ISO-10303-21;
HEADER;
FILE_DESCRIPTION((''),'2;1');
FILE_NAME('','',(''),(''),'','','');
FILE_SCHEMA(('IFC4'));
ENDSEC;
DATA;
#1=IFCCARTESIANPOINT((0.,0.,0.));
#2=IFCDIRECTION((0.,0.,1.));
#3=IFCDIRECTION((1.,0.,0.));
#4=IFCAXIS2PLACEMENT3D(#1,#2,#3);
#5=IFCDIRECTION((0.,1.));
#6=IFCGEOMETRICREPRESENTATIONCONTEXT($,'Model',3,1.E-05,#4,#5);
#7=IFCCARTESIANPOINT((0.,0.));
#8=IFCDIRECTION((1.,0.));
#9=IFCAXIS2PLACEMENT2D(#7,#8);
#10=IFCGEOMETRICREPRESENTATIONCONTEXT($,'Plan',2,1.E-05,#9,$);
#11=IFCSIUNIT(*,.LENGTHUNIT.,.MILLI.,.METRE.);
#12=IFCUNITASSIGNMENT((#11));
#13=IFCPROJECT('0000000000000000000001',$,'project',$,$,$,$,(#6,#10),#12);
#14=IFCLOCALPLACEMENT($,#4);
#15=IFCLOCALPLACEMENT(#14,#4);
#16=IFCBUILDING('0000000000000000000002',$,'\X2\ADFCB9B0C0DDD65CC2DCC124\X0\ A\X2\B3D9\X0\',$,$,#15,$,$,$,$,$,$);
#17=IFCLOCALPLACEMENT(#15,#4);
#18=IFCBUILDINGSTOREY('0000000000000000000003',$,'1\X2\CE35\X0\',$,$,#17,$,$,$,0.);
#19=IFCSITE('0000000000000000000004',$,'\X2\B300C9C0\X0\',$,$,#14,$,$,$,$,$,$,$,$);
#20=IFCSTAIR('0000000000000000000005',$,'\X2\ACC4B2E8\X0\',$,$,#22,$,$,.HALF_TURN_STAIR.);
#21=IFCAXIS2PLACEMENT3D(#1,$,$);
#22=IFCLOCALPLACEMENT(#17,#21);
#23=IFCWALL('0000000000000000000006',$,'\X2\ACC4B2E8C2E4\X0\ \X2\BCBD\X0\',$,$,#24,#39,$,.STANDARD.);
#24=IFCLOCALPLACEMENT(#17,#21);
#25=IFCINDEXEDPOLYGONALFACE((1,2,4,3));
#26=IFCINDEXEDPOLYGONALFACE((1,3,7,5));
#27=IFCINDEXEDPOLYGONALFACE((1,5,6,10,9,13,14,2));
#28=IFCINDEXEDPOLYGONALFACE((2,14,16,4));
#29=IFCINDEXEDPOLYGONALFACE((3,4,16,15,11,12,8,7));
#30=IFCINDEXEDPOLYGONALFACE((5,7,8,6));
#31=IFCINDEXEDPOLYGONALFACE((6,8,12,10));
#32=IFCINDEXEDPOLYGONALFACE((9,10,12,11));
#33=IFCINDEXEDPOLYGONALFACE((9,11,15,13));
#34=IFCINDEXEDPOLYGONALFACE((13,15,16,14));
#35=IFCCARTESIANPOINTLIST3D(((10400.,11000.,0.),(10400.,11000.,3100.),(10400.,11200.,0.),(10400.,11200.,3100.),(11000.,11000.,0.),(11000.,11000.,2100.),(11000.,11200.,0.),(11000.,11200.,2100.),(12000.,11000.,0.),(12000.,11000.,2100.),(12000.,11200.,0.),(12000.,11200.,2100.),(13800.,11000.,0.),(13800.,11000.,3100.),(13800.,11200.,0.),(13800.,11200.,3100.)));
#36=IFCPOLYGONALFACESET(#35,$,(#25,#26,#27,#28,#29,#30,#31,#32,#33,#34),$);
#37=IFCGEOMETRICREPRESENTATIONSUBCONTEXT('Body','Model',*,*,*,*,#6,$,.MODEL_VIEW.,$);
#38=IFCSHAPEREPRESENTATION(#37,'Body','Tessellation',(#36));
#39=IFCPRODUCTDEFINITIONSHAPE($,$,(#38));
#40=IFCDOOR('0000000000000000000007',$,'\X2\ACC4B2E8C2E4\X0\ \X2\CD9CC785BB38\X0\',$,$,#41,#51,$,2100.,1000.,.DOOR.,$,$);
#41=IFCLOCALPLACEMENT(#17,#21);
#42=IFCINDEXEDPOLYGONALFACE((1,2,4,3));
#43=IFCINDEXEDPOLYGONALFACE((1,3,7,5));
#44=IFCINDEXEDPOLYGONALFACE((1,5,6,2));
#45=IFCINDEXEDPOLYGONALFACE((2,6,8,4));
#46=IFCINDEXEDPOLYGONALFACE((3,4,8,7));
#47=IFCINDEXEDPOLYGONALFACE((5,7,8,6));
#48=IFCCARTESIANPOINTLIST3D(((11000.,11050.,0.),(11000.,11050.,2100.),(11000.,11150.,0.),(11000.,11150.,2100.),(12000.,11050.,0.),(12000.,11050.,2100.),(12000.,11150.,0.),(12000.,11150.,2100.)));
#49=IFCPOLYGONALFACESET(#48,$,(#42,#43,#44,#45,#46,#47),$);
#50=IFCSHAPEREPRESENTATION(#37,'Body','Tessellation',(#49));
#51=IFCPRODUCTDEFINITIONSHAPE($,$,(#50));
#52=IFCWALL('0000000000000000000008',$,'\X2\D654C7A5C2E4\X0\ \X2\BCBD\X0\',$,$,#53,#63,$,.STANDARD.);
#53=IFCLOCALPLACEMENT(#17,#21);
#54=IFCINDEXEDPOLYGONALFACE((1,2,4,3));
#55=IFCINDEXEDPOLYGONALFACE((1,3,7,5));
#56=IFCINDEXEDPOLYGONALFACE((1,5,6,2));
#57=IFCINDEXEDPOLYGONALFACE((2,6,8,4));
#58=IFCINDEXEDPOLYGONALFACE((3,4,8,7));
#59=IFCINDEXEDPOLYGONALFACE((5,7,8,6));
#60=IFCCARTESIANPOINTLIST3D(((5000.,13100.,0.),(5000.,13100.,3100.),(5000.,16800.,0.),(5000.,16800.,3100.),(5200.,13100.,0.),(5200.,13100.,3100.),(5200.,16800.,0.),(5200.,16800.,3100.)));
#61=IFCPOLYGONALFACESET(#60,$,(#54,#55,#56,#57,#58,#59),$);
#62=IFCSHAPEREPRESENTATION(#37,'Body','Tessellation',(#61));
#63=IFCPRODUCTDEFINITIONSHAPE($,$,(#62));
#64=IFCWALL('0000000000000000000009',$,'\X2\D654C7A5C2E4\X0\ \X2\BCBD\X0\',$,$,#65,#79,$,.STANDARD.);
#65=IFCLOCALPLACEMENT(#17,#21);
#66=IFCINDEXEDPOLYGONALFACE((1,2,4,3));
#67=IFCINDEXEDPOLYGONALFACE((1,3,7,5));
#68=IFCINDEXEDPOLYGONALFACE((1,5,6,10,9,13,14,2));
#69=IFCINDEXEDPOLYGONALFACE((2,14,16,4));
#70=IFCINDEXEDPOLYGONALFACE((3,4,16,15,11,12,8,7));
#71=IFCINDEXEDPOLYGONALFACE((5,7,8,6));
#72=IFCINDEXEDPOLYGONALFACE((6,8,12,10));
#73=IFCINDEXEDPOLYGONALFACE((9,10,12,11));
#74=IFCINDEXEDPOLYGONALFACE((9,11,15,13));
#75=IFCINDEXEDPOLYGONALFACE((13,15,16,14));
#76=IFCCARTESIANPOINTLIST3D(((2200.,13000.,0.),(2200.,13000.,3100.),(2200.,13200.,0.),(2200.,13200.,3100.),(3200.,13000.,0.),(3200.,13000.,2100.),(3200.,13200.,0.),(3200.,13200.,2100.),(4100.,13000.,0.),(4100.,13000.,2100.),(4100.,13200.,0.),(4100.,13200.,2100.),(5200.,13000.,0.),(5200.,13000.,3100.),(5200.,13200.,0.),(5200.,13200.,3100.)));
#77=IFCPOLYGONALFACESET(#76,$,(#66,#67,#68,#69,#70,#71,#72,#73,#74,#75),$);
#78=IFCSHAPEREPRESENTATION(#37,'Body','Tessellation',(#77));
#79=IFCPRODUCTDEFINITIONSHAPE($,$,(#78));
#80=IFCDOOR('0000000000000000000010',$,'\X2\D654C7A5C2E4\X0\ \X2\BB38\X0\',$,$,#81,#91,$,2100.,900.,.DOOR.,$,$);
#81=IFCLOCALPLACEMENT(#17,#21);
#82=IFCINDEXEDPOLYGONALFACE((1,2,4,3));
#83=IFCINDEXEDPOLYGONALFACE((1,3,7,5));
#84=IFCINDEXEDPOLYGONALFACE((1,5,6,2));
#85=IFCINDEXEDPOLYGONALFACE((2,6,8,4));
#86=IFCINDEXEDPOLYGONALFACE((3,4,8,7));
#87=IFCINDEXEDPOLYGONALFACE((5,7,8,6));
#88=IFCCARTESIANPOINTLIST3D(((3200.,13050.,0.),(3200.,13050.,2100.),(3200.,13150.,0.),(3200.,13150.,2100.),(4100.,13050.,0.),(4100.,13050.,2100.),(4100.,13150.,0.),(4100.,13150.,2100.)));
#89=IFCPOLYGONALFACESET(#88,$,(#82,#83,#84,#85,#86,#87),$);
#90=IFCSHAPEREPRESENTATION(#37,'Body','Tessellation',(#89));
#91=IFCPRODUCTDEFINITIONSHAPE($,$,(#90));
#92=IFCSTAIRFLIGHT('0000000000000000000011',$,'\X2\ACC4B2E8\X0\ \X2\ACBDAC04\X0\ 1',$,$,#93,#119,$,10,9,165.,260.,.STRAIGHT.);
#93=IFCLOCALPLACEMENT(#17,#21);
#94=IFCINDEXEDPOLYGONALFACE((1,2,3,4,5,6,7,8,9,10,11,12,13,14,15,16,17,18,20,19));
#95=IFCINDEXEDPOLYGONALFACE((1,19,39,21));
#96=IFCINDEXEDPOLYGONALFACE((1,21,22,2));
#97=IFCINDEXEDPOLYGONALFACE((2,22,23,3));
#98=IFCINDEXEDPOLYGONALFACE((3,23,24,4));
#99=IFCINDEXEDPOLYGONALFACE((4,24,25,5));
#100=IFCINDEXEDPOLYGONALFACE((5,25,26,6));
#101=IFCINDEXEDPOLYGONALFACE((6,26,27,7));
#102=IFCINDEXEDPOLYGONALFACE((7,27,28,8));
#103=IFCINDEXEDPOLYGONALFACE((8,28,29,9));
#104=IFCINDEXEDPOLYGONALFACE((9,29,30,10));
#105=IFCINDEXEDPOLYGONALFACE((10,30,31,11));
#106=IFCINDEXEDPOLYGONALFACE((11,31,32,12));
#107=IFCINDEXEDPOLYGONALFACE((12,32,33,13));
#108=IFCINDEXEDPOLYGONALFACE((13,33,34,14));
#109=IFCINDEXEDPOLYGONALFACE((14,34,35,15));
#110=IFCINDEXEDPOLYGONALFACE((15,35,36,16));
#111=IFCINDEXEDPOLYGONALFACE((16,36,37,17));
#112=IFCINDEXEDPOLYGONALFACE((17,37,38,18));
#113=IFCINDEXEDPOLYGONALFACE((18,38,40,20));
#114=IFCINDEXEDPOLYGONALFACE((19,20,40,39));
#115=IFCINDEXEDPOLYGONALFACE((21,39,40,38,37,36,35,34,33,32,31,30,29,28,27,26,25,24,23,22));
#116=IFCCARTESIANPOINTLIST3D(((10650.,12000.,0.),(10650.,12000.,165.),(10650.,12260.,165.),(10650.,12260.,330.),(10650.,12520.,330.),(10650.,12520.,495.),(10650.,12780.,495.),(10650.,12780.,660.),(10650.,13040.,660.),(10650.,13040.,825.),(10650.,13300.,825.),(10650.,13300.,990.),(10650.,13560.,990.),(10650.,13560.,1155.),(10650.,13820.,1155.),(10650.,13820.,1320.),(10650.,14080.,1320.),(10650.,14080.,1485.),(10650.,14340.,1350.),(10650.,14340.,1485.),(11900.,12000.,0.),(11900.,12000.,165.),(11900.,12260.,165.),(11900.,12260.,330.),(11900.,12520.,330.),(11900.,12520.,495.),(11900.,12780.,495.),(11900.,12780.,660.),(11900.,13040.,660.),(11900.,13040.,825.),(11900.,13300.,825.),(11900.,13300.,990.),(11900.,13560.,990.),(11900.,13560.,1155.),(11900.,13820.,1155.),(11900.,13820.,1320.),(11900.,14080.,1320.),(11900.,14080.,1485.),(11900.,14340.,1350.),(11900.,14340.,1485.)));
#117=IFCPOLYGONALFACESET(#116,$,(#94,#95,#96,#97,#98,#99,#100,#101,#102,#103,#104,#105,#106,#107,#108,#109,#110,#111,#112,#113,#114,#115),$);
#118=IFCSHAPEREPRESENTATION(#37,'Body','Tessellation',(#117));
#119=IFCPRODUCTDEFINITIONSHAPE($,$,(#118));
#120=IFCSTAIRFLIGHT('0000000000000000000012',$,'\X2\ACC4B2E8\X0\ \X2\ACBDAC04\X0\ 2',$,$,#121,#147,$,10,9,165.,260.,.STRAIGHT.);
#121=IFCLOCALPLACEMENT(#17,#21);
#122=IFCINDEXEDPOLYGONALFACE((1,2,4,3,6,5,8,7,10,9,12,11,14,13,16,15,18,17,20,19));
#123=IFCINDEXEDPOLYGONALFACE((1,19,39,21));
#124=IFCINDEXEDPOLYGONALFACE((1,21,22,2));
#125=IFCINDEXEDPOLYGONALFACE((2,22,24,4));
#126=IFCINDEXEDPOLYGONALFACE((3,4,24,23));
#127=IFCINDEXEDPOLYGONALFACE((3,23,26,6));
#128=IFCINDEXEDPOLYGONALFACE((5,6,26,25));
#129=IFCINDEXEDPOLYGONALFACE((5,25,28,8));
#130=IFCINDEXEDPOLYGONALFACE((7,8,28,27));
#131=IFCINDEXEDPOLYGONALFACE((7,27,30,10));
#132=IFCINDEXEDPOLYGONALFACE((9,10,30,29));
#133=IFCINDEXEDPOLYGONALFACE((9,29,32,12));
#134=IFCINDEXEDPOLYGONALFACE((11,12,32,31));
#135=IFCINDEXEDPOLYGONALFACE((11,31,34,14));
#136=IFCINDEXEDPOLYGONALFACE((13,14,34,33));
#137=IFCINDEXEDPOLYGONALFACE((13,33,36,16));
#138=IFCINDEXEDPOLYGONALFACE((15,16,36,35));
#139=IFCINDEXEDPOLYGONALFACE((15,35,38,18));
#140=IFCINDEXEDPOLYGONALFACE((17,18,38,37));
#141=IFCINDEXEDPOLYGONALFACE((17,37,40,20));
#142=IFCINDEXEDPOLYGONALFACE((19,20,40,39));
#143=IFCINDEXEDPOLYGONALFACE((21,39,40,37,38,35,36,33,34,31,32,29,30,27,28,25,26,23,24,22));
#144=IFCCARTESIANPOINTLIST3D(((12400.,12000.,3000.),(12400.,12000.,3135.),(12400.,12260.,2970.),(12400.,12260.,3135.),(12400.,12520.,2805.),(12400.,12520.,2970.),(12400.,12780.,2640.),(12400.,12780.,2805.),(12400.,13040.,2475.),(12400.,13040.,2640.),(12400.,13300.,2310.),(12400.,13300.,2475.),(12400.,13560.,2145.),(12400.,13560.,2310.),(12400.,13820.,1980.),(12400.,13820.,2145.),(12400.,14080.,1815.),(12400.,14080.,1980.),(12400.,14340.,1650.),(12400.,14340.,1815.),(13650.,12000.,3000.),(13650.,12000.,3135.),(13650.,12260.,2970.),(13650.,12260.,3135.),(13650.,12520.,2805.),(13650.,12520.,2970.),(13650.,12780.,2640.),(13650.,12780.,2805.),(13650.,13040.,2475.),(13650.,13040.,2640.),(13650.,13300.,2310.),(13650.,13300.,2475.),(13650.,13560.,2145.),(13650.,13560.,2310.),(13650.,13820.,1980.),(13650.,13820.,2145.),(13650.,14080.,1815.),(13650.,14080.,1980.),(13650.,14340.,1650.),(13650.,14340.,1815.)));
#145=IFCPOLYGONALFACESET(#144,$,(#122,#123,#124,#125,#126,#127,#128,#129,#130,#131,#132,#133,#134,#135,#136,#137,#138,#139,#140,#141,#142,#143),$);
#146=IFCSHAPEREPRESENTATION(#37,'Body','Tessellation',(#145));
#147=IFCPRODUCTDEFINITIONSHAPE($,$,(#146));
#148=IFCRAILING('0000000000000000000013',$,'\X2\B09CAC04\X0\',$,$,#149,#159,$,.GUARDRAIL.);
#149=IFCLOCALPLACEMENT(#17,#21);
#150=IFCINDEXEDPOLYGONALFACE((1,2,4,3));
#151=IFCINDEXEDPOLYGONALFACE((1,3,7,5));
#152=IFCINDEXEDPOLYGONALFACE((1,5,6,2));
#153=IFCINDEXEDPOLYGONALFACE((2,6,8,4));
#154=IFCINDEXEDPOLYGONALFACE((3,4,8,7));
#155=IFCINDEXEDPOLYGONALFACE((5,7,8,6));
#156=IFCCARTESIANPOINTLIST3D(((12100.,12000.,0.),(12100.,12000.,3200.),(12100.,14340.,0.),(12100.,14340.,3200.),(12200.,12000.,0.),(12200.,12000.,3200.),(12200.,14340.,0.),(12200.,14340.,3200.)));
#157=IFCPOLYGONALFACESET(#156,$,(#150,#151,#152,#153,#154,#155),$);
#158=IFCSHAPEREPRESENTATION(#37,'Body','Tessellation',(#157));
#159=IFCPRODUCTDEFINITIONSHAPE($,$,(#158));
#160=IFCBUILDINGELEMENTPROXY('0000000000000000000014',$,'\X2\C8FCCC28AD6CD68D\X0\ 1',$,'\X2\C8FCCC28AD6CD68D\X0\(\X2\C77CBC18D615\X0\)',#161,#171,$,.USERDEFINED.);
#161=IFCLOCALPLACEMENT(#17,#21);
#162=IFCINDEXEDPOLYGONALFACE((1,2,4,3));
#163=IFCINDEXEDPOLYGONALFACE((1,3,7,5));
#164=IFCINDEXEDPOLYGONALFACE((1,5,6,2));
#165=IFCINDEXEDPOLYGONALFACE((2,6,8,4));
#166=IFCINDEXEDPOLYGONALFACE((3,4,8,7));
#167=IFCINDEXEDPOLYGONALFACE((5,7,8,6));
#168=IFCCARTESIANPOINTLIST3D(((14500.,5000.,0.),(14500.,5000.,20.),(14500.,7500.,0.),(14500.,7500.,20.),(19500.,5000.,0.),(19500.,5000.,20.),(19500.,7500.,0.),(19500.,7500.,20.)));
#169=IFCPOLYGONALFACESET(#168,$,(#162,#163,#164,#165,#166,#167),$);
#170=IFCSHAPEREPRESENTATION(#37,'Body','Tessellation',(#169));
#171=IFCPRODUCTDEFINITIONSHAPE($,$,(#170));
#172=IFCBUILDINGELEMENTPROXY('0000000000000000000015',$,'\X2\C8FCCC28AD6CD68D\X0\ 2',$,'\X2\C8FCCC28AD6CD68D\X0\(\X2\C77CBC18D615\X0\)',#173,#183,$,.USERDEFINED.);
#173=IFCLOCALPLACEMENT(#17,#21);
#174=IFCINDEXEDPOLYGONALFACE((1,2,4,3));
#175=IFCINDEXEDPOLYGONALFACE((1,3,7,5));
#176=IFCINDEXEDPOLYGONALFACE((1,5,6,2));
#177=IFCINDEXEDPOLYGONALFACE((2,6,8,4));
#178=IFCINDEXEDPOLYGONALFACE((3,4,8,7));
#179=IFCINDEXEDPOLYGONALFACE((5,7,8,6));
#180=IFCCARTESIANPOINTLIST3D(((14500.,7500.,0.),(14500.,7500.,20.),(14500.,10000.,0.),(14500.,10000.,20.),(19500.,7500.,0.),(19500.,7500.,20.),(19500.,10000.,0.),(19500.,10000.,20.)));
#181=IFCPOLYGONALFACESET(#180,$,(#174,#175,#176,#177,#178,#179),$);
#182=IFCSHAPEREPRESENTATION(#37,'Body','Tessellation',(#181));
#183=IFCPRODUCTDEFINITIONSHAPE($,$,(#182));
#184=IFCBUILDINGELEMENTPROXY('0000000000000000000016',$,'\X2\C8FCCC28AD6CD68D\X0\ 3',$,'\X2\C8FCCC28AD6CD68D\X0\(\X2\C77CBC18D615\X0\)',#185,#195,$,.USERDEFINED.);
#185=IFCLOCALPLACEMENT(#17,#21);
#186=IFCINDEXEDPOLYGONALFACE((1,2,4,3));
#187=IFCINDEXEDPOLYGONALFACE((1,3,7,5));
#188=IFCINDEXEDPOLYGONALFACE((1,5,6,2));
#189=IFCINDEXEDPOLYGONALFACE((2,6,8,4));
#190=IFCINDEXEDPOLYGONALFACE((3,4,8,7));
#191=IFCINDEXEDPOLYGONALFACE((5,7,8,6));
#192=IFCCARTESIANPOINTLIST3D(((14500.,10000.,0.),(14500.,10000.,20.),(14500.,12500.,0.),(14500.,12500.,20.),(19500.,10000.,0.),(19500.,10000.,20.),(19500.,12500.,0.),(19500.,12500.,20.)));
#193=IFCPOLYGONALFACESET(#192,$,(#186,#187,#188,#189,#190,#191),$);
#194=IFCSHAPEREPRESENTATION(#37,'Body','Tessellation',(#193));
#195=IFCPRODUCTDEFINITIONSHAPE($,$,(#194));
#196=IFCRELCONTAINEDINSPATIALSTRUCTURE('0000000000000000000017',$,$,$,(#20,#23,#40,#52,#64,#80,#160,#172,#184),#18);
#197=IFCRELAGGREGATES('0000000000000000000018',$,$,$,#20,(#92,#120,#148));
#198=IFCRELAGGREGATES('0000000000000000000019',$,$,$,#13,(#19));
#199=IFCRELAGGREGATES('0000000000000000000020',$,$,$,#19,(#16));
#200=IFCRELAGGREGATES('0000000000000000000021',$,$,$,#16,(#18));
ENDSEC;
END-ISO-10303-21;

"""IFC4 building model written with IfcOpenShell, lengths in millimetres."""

from ifc_helpers import new_model, si_unit, direction, frame, origin_with_axes, origin_2d_with_axis, place, context, subcontext, project, spatial, polyline, outline, extrude, element, fill, aggregate, save


model = new_model("IFC4")

# Units and contexts
model_context = context("Model", 3, precision=1e-05, world=origin_with_axes(), true_north=direction((0.0, 1.0)))
plan_context = context("Plan", 2, precision=1e-05, world=origin_2d_with_axis())
body_context = subcontext(model_context, "Body", "Model", "MODEL_VIEW")
ifc_project = project(units=[si_unit("LENGTHUNIT", "METRE", prefix="MILLI")], contexts=[model_context, plan_context])

# Site, building, storey
site_placement = place(None, origin_with_axes())
site = spatial("IfcSite", under=ifc_project, at=site_placement, Name="대지")
building_placement = place(site_placement, origin_with_axes())
building = spatial("IfcBuilding", under=site, at=building_placement, Name="근린생활시설 A동")
storey_placement = place(building_placement, origin_with_axes())
storey = spatial("IfcBuildingStorey", under=building, at=storey_placement, Name="1층", Elevation=0.0)

# Stair
stair_placement = place(storey_placement, origin_with_axes())
stair = element("IfcStair", 1, at=stair_placement, inside=storey, Name="계단", PredefinedType="HALF_TURN_STAIR")

# Wall, opening, door
wall_1_placement = place(storey_placement, origin_with_axes())
wall_1 = element("IfcWall", 2, at=wall_1_placement, inside=storey, Name="계단실 벽", PredefinedType="STANDARD", context=body_context, shape_type="SweptSolid", body=[
    extrude(outline(polyline([(10400.0, 11200.0), (13800.0, 11200.0), (13800.0, 11000.0), (10400.0, 11000.0), (10400.0, 11200.0)])), origin_with_axes(), (0.0, 0.0, 1.0), 3100.0),
])
opening_1_placement = place(storey_placement, origin_with_axes())
opening_1 = element("IfcOpeningElement", 3, at=opening_1_placement, cuts=wall_1, PredefinedType="OPENING", context=body_context, shape_type="SweptSolid", body=[
    extrude(outline(polyline([(11000.0, 10950.0), (12000.0, 10950.0), (12000.0, 11250.0), (11000.0, 11250.0), (11000.0, 10950.0)])), origin_with_axes(), (0.0, 0.0, 1.0), 2100.0),
])
door_1_placement = place(storey_placement, origin_with_axes())
door_1 = element("IfcDoor", 4, at=door_1_placement, inside=storey, Name="계단실 출입문", OverallHeight=2100.0, OverallWidth=1000.0, PredefinedType="DOOR", context=body_context, shape_type="SweptSolid", body=[
    extrude(outline(polyline([(11000.0, 11050.0), (12000.0, 11050.0), (12000.0, 11150.0), (11000.0, 11150.0), (11000.0, 11050.0)])), origin_with_axes(), (0.0, 0.0, 1.0), 2100.0),
])
fill(opening_1, door_1)

# Wall
wall_2_placement = place(storey_placement, origin_with_axes())
element("IfcWall", 5, at=wall_2_placement, inside=storey, Name="화장실 벽", PredefinedType="STANDARD", context=body_context, shape_type="SweptSolid", body=[
    extrude(outline(polyline([(5000.0, 13100.0), (5000.0, 16800.0), (5200.0, 16800.0), (5200.0, 13100.0), (5000.0, 13100.0)])), origin_with_axes(), (0.0, 0.0, 1.0), 3100.0),
])

# Wall, opening, door
wall_3_placement = place(storey_placement, origin_with_axes())
wall_3 = element("IfcWall", 6, at=wall_3_placement, inside=storey, Name="화장실 벽", PredefinedType="STANDARD", context=body_context, shape_type="SweptSolid", body=[
    extrude(outline(polyline([(2200.0, 13200.0), (5200.0, 13200.0), (5200.0, 13000.0), (2200.0, 13000.0), (2200.0, 13200.0)])), origin_with_axes(), (0.0, 0.0, 1.0), 3100.0),
])
opening_2_placement = place(storey_placement, origin_with_axes())
opening_2 = element("IfcOpeningElement", 7, at=opening_2_placement, cuts=wall_3, PredefinedType="OPENING", context=body_context, shape_type="SweptSolid", body=[
    extrude(outline(polyline([(3200.0, 12950.0), (4100.0, 12950.0), (4100.0, 13250.0), (3200.0, 13250.0), (3200.0, 12950.0)])), origin_with_axes(), (0.0, 0.0, 1.0), 2100.0),
])
door_2_placement = place(storey_placement, origin_with_axes())
door_2 = element("IfcDoor", 8, at=door_2_placement, inside=storey, Name="화장실 문", OverallHeight=2100.0, OverallWidth=900.0, PredefinedType="DOOR", context=body_context, shape_type="SweptSolid", body=[
    extrude(outline(polyline([(3200.0, 13050.0), (4100.0, 13050.0), (4100.0, 13150.0), (3200.0, 13150.0), (3200.0, 13050.0)])), origin_with_axes(), (0.0, 0.0, 1.0), 2100.0),
])
fill(opening_2, door_2)

# Stair flights
stair_flight_1_placement = place(stair_placement, origin_with_axes())
stair_flight_1 = element("IfcStairFlight", 9, at=stair_flight_1_placement, Name="계단 경간 1", NumberOfRisers=10, NumberOfTreads=9, PredefinedType="STRAIGHT", RiserHeight=165.0, TreadLength=260.0, context=body_context, shape_type="SweptSolid", body=[
    extrude(outline(polyline([(0.0, 0.0), (0.0, 165.0), (260.0, 165.0), (260.0, 330.0), (520.0, 330.0), (520.0, 495.0), (780.0, 495.0), (780.0, 660.0), (1040.0, 660.0), (1040.0, 825.0), (1300.0, 825.0), (1300.0, 990.0), (1560.0, 990.0), (1560.0, 1155.0), (1820.0, 1155.0), (1820.0, 1320.0), (2080.0, 1320.0), (2080.0, 1485.0), (2340.0, 1485.0), (2340.0, 1650.0), (2340.0, 1350.0), (0.0, 0.0)])), frame((10650.0, 12000.0, 0.0), z_axis=(1.0, 0.0, 0.0), x_axis=(0.0, 1.0, 0.0)), (0.0, 0.0, 1.0), 1250.0),
])
stair_flight_2_placement = place(stair_placement, origin_with_axes())
stair_flight_2 = element("IfcStairFlight", 10, at=stair_flight_2_placement, Name="계단 경간 2", NumberOfRisers=10, NumberOfTreads=9, PredefinedType="STRAIGHT", RiserHeight=165.0, TreadLength=260.0, context=body_context, shape_type="SweptSolid", body=[
    extrude(outline(polyline([(0.0, 0.0), (0.0, 165.0), (260.0, 165.0), (260.0, 330.0), (520.0, 330.0), (520.0, 495.0), (780.0, 495.0), (780.0, 660.0), (1040.0, 660.0), (1040.0, 825.0), (1300.0, 825.0), (1300.0, 990.0), (1560.0, 990.0), (1560.0, 1155.0), (1820.0, 1155.0), (1820.0, 1320.0), (2080.0, 1320.0), (2080.0, 1485.0), (2340.0, 1485.0), (2340.0, 1650.0), (2340.0, 1350.0), (0.0, 0.0)])), frame((13650.0, 14340.0, 1650.0), z_axis=(-1.0, 0.0, 0.0), x_axis=(0.0, -1.0, 0.0)), (0.0, 0.0, 1.0), 1250.0),
])

# Railing
railing_placement = place(stair_placement, origin_with_axes())
railing = element("IfcRailing", 11, at=railing_placement, Name="난간", PredefinedType="GUARDRAIL", context=body_context, shape_type="SweptSolid", body=[
    extrude(outline(polyline([(12100.0, 12000.0), (12200.0, 12000.0), (12200.0, 14340.0), (12100.0, 14340.0), (12100.0, 12000.0)])), origin_with_axes(), (0.0, 0.0, 1.0), 3200.0),
])
aggregate(stair, [stair_flight_1, stair_flight_2, railing])

# Building element proxies
proxy_1_placement = place(storey_placement, origin_with_axes())
element("IfcBuildingElementProxy", 12, at=proxy_1_placement, inside=storey, Name="주차구획 1", ObjectType="주차구획(일반형)", PredefinedType="USERDEFINED", context=body_context, shape_type="SweptSolid", body=[
    extrude(outline(polyline([(14500.0, 5000.0), (19500.0, 5000.0), (19500.0, 7500.0), (14500.0, 7500.0), (14500.0, 5000.0)])), origin_with_axes(), (0.0, 0.0, 1.0), 20.0),
])
proxy_2_placement = place(storey_placement, origin_with_axes())
element("IfcBuildingElementProxy", 13, at=proxy_2_placement, inside=storey, Name="주차구획 2", ObjectType="주차구획(일반형)", PredefinedType="USERDEFINED", context=body_context, shape_type="SweptSolid", body=[
    extrude(outline(polyline([(14500.0, 7500.0), (19500.0, 7500.0), (19500.0, 10000.0), (14500.0, 10000.0), (14500.0, 7500.0)])), origin_with_axes(), (0.0, 0.0, 1.0), 20.0),
])
proxy_3_placement = place(storey_placement, origin_with_axes())
element("IfcBuildingElementProxy", 14, at=proxy_3_placement, inside=storey, Name="주차구획 3", ObjectType="주차구획(일반형)", PredefinedType="USERDEFINED", context=body_context, shape_type="SweptSolid", body=[
    extrude(outline(polyline([(14500.0, 10000.0), (19500.0, 10000.0), (19500.0, 12500.0), (14500.0, 12500.0), (14500.0, 10000.0)])), origin_with_axes(), (0.0, 0.0, 1.0), 20.0),
])

save(model, "model.ifc")
